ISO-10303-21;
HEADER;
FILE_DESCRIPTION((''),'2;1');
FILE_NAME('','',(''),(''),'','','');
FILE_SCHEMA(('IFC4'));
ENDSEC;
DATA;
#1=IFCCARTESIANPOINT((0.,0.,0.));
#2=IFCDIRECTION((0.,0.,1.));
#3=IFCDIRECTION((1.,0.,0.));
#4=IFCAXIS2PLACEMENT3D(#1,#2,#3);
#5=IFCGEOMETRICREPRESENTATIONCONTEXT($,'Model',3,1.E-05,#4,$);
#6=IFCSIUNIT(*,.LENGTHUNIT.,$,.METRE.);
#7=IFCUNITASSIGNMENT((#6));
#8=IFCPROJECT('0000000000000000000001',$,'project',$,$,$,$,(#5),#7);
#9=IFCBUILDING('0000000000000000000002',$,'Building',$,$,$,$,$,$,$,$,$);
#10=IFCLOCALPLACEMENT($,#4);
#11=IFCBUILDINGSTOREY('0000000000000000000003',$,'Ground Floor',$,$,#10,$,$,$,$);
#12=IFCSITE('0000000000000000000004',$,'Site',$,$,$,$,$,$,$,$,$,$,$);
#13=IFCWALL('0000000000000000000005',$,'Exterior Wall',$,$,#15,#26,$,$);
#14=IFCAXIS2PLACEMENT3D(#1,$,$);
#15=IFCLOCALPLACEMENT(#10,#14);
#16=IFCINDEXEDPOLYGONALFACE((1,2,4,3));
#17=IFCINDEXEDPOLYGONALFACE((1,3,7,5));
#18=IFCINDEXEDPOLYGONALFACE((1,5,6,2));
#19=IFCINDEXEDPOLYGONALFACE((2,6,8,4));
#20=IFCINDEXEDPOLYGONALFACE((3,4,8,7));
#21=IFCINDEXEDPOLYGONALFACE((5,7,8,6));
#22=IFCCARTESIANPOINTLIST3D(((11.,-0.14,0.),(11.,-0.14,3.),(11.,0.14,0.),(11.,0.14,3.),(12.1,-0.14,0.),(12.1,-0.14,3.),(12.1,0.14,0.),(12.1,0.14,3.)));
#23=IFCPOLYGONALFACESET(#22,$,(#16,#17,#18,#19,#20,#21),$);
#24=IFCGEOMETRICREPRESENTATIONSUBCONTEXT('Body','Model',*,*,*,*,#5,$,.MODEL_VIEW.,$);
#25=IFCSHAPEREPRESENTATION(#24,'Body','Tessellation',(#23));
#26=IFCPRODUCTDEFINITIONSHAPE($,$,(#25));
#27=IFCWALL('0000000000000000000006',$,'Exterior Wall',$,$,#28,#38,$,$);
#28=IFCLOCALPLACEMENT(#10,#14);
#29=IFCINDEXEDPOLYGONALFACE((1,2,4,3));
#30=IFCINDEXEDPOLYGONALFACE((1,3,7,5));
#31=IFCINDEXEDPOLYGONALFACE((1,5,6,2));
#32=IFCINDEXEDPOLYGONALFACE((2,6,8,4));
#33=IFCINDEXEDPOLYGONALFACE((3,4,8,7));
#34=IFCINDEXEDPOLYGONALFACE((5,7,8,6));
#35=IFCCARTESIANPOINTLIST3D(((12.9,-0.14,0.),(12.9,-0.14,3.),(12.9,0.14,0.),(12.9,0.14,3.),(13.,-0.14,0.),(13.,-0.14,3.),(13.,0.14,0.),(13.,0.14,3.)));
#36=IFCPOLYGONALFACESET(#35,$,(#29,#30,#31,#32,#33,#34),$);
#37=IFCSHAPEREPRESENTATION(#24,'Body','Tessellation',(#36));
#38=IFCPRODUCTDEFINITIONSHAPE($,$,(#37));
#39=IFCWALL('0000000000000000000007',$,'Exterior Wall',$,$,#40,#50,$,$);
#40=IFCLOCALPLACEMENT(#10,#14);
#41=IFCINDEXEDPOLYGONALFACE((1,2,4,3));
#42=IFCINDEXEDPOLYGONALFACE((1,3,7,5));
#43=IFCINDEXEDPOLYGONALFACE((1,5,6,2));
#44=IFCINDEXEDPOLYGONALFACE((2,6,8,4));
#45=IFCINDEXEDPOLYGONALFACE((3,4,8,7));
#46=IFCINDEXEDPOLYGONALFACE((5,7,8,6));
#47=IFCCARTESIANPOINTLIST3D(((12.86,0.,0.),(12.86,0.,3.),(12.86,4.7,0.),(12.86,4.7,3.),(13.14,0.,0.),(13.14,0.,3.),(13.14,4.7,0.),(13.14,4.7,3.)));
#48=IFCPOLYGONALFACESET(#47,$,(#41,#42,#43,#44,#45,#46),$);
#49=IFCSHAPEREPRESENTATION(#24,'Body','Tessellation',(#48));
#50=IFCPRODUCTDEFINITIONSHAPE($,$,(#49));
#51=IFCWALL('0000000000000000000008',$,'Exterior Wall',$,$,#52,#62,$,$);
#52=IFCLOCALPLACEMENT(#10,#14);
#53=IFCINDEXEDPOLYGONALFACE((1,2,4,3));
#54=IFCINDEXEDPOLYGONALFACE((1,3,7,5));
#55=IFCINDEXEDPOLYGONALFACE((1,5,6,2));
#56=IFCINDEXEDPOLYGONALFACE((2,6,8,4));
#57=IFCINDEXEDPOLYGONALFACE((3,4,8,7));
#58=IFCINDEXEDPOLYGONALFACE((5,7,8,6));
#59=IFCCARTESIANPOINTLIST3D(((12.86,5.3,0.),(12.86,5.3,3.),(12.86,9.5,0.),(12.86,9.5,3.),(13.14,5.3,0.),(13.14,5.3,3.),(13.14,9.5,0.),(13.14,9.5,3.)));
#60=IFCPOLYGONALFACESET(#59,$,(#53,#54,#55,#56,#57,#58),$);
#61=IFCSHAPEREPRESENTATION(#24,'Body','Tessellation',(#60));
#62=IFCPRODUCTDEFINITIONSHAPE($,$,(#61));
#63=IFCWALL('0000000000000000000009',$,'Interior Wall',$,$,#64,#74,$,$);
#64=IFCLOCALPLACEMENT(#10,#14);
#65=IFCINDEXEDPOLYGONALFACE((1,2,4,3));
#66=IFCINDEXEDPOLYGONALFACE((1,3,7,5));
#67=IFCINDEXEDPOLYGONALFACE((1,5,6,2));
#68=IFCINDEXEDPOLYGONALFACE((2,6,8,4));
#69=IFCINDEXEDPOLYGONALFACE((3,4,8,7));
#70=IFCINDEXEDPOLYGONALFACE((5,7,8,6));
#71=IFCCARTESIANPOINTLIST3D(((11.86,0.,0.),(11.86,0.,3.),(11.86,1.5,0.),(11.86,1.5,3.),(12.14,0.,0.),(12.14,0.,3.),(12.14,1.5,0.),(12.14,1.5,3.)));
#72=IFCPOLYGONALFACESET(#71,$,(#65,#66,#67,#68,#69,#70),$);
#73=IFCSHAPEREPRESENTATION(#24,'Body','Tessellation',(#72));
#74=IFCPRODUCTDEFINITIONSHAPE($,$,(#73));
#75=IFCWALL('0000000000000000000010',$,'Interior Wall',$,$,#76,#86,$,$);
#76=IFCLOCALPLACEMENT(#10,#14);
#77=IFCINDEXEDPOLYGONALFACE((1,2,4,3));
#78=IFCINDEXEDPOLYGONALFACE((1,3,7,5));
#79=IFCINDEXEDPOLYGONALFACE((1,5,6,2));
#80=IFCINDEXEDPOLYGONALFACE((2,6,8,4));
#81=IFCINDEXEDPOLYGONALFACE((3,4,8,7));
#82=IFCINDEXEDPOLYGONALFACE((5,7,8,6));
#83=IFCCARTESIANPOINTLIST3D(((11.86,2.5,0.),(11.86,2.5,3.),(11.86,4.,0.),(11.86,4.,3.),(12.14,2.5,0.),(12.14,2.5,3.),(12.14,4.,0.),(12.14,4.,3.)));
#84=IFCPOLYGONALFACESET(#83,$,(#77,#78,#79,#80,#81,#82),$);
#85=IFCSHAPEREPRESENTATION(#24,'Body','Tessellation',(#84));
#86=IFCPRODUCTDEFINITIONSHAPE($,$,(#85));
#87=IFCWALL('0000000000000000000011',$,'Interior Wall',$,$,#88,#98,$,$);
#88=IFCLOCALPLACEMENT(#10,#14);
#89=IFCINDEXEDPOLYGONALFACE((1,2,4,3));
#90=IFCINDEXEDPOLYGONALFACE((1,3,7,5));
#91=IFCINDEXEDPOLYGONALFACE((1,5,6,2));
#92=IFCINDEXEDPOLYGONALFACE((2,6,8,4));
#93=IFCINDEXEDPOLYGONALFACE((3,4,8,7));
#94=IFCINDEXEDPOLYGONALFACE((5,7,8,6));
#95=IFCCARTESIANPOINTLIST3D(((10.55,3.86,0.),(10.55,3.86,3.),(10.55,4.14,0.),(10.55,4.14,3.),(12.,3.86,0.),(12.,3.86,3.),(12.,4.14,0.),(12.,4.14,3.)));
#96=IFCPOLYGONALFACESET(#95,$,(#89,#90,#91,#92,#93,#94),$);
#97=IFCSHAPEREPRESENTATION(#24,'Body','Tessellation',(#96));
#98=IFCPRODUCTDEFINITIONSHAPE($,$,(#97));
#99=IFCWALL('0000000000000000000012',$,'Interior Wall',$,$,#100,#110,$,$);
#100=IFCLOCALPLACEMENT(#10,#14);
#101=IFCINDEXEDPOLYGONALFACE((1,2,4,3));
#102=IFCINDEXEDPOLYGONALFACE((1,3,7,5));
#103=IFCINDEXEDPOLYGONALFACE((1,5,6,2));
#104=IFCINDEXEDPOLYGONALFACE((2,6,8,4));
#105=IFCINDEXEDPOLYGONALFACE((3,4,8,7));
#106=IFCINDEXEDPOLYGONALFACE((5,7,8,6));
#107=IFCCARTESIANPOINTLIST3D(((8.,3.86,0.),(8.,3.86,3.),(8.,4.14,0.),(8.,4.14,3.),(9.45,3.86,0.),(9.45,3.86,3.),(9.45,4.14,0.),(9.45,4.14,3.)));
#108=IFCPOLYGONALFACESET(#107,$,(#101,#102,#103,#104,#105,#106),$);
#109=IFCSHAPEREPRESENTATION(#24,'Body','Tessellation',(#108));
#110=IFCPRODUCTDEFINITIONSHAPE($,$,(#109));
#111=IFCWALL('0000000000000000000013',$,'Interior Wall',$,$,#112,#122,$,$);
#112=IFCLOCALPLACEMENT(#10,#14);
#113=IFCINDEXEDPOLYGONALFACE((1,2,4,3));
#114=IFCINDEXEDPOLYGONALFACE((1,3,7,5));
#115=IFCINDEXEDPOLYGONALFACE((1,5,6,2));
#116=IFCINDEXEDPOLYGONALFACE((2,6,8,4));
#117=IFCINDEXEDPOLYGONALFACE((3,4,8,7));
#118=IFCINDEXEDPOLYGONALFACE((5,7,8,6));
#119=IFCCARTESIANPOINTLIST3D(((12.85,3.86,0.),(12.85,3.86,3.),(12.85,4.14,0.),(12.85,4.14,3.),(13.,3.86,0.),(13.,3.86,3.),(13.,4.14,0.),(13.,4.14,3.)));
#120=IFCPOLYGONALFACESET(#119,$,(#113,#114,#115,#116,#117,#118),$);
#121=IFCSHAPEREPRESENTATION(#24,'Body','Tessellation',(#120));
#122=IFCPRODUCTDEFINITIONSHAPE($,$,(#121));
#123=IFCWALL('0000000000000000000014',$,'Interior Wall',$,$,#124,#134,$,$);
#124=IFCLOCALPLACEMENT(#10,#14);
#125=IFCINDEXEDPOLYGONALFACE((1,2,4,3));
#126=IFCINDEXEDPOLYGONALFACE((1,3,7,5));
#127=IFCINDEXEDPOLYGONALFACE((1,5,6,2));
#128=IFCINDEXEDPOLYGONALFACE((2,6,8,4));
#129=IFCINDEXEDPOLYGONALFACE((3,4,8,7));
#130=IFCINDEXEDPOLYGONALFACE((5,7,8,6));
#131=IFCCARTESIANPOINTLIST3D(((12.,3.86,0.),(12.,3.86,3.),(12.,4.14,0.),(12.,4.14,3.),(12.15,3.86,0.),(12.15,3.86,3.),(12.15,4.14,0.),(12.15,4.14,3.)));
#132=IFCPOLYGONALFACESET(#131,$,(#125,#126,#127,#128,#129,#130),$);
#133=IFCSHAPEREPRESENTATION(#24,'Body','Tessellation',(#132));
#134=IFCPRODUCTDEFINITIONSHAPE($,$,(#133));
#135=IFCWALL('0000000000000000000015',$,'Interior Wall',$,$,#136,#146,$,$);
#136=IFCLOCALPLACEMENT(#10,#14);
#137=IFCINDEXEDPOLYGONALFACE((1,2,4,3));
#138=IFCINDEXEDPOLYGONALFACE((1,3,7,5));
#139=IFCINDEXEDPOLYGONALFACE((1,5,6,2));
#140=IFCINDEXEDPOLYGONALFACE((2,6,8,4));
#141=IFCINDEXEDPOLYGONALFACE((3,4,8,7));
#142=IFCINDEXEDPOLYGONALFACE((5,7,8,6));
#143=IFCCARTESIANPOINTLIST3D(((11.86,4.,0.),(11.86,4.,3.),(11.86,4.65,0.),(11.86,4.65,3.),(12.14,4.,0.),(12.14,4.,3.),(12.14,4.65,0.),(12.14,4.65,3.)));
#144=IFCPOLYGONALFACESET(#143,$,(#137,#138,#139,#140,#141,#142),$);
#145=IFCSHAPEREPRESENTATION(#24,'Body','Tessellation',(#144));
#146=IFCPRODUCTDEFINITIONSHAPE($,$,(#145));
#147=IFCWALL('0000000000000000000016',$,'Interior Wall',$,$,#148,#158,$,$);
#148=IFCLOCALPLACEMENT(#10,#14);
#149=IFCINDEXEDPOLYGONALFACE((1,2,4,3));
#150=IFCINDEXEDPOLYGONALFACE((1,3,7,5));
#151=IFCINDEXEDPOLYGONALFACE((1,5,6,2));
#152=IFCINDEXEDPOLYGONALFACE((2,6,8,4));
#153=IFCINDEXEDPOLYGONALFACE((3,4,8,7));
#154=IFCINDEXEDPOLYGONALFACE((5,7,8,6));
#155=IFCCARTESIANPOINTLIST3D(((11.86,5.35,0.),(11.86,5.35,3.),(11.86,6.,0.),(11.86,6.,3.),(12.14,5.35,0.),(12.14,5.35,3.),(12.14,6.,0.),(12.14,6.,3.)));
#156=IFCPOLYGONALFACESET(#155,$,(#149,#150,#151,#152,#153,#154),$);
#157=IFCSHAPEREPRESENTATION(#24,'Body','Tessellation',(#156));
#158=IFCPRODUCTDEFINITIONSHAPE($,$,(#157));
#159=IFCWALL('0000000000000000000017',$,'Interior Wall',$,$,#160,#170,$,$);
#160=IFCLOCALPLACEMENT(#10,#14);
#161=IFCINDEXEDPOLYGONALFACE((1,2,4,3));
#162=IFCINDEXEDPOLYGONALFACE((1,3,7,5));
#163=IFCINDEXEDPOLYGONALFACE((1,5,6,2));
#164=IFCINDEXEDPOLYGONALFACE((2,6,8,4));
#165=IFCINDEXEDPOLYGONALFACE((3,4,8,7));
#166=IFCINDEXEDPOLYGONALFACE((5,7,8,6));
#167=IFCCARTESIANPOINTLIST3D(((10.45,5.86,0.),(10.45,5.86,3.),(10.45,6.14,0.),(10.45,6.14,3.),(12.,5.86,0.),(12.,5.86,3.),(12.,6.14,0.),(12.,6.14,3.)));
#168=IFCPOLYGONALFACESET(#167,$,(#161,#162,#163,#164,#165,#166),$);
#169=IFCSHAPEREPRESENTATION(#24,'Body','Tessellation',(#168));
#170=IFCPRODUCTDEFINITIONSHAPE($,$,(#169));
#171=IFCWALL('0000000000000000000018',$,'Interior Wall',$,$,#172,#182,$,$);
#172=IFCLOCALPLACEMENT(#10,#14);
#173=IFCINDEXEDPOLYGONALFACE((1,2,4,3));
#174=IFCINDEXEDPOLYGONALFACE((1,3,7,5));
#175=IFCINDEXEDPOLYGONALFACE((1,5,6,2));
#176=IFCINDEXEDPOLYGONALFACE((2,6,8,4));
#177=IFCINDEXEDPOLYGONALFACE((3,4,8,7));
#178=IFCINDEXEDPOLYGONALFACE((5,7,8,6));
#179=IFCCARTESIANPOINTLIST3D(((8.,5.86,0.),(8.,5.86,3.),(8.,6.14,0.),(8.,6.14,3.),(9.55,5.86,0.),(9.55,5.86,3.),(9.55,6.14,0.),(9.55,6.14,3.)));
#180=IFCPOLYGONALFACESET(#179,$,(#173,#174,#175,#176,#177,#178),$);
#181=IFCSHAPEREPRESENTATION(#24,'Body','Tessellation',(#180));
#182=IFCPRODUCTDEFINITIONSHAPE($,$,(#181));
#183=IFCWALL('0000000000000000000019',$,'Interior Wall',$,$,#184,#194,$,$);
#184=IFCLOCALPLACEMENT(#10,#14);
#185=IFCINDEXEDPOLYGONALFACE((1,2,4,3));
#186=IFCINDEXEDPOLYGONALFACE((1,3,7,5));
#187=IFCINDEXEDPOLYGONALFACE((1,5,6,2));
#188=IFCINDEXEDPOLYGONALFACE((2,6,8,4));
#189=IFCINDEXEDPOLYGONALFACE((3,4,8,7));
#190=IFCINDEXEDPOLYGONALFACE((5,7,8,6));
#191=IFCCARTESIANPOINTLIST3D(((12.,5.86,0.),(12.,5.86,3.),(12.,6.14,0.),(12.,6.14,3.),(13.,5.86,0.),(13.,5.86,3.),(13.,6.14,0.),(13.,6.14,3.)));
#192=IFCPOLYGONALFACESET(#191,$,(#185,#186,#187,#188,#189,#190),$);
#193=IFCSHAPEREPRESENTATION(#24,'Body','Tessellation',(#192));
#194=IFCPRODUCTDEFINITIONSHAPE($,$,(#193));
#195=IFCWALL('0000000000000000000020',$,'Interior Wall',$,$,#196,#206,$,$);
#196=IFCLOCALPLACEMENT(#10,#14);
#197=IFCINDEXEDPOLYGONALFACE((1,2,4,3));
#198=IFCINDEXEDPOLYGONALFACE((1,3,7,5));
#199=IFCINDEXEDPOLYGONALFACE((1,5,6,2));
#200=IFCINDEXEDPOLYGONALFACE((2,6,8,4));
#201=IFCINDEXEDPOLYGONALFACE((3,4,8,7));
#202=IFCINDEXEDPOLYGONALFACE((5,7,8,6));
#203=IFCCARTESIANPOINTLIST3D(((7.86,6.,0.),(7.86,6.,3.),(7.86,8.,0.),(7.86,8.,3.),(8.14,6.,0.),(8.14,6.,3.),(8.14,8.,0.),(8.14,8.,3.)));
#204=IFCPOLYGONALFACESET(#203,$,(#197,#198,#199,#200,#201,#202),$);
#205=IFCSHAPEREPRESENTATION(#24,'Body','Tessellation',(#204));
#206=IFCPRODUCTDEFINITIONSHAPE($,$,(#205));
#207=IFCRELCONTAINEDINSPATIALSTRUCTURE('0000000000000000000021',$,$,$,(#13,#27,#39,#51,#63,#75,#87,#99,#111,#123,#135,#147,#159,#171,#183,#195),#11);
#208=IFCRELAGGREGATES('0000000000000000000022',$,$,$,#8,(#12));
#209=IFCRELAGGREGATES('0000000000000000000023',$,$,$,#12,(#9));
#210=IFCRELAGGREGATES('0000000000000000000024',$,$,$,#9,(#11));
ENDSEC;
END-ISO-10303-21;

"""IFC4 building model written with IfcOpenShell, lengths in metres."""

from ifc_helpers import new_model, si_unit, frame, origin_with_axes, place, context, subcontext, project, spatial, indexed_curve, outline, extrude, element, save


model = new_model("IFC4")

# Units and contexts
model_context = context("Model", 3, precision=1e-05, world=origin_with_axes())
body_context = subcontext(model_context, "Body", "Model", "MODEL_VIEW")
ifc_project = project(units=[si_unit("LENGTHUNIT", "METRE")], contexts=[model_context])

# Site, building, storey
site = spatial("IfcSite", under=ifc_project, Name="Site")
building = spatial("IfcBuilding", under=site, Name="Building")
storey_placement = place(None, origin_with_axes())
storey = spatial("IfcBuildingStorey", under=building, at=storey_placement, Name="Ground Floor")

# Walls
wall_1_placement = place(storey_placement, frame((11.0, 0.0, 0.0), z_axis=(0.0, 0.0, 1.0), x_axis=(1.0, 0.0, 0.0)))
element("IfcWall", 1, at=wall_1_placement, inside=storey, Name="Exterior Wall", context=body_context, shape_type="SweptSolid", body=[
    extrude(outline(indexed_curve([(0.0, 0.0), (0.0, 0.28), (1.1, 0.28), (1.1, 0.0), (0.0, 0.0)], self_intersect=False)), frame((0.0, -0.14, 0.0), z_axis=(0.0, 0.0, 1.0), x_axis=(1.0, 0.0, 0.0)), (0.0, 0.0, 1.0), 3.0),
])
wall_2_placement = place(storey_placement, frame((12.9, 0.0, 0.0), z_axis=(0.0, 0.0, 1.0), x_axis=(1.0, 0.0, 0.0)))
element("IfcWall", 2, at=wall_2_placement, inside=storey, Name="Exterior Wall", context=body_context, shape_type="SweptSolid", body=[
    extrude(outline(indexed_curve([(0.0, 0.0), (0.0, 0.28), (0.1, 0.28), (0.1, 0.0), (0.0, 0.0)], self_intersect=False)), frame((0.0, -0.14, 0.0), z_axis=(0.0, 0.0, 1.0), x_axis=(1.0, 0.0, 0.0)), (0.0, 0.0, 1.0), 3.0),
])
wall_3_placement = place(storey_placement, frame((13.0, 0.0, 0.0), z_axis=(0.0, 0.0, 1.0), x_axis=(0.0, 1.0, 0.0)))
element("IfcWall", 3, at=wall_3_placement, inside=storey, Name="Exterior Wall", context=body_context, shape_type="SweptSolid", body=[
    extrude(outline(indexed_curve([(0.0, 0.0), (0.0, 0.28), (4.7, 0.28), (4.7, 0.0), (0.0, 0.0)], self_intersect=False)), frame((0.0, -0.14, 0.0), z_axis=(0.0, 0.0, 1.0), x_axis=(1.0, 0.0, 0.0)), (0.0, 0.0, 1.0), 3.0),
])
wall_4_placement = place(storey_placement, frame((13.0, 5.3, 0.0), z_axis=(0.0, 0.0, 1.0), x_axis=(0.0, 1.0, 0.0)))
element("IfcWall", 4, at=wall_4_placement, inside=storey, Name="Exterior Wall", context=body_context, shape_type="SweptSolid", body=[
    extrude(outline(indexed_curve([(0.0, 0.0), (0.0, 0.28), (4.2, 0.28), (4.2, 0.0), (0.0, 0.0)], self_intersect=False)), frame((0.0, -0.14, 0.0), z_axis=(0.0, 0.0, 1.0), x_axis=(1.0, 0.0, 0.0)), (0.0, 0.0, 1.0), 3.0),
])
for number, where, z_axis, x_axis, name in (
    (5, (12.0, 0.0, 0.0), (0.0, 0.0, 1.0), (0.0, 1.0, 0.0), "Interior Wall"),
    (6, (12.0, 2.5, 0.0), (0.0, 0.0, 1.0), (0.0, 1.0, 0.0), "Interior Wall"),
):
    element("IfcWall", number, at=place(storey_placement, frame(where, z_axis=z_axis, x_axis=x_axis)), inside=storey, Name=name, context=body_context, shape_type="SweptSolid", body=[
        extrude(outline(indexed_curve([(0.0, 0.0), (0.0, 0.28), (1.5, 0.28), (1.5, 0.0), (0.0, 0.0)], self_intersect=False)), frame((0.0, -0.14, 0.0), z_axis=(0.0, 0.0, 1.0), x_axis=(1.0, 0.0, 0.0)), (0.0, 0.0, 1.0), 3.0),
    ])
for number, where, z_axis, x_axis, name in (
    (7, (12.0, 4.0, 0.0), (0.0, 0.0, 1.0), (-1.0, 0.0, 0.0), "Interior Wall"),
    (8, (9.45, 4.0, 0.0), (0.0, 0.0, 1.0), (-1.0, 0.0, 0.0), "Interior Wall"),
):
    element("IfcWall", number, at=place(storey_placement, frame(where, z_axis=z_axis, x_axis=x_axis)), inside=storey, Name=name, context=body_context, shape_type="SweptSolid", body=[
        extrude(outline(indexed_curve([(0.0, 0.0), (0.0, 0.28), (1.45, 0.28), (1.45, 0.0), (0.0, 0.0)], self_intersect=False)), frame((0.0, -0.14, 0.0), z_axis=(0.0, 0.0, 1.0), x_axis=(1.0, 0.0, 0.0)), (0.0, 0.0, 1.0), 3.0),
    ])
for number, where, z_axis, x_axis, name in (
    (9, (13.0, 4.0, 0.0), (0.0, 0.0, 1.0), (-1.0, 0.0, 0.0), "Interior Wall"),
    (10, (12.15, 4.0, 0.0), (0.0, 0.0, 1.0), (-1.0, 0.0, 0.0), "Interior Wall"),
):
    element("IfcWall", number, at=place(storey_placement, frame(where, z_axis=z_axis, x_axis=x_axis)), inside=storey, Name=name, context=body_context, shape_type="SweptSolid", body=[
        extrude(outline(indexed_curve([(0.0, 0.0), (0.0, 0.28), (0.15, 0.28), (0.15, 0.0), (0.0, 0.0)], self_intersect=False)), frame((0.0, -0.14, 0.0), z_axis=(0.0, 0.0, 1.0), x_axis=(1.0, 0.0, 0.0)), (0.0, 0.0, 1.0), 3.0),
    ])
for number, where, z_axis, x_axis, name in (
    (11, (12.0, 4.0, 0.0), (0.0, 0.0, 1.0), (0.0, 1.0, 0.0), "Interior Wall"),
    (12, (12.0, 5.35, 0.0), (0.0, 0.0, 1.0), (0.0, 1.0, 0.0), "Interior Wall"),
):
    element("IfcWall", number, at=place(storey_placement, frame(where, z_axis=z_axis, x_axis=x_axis)), inside=storey, Name=name, context=body_context, shape_type="SweptSolid", body=[
        extrude(outline(indexed_curve([(0.0, 0.0), (0.0, 0.28), (0.65, 0.28), (0.65, 0.0), (0.0, 0.0)], self_intersect=False)), frame((0.0, -0.14, 0.0), z_axis=(0.0, 0.0, 1.0), x_axis=(1.0, 0.0, 0.0)), (0.0, 0.0, 1.0), 3.0),
    ])
for number, where, z_axis, x_axis, name in (
    (13, (12.0, 6.0, 0.0), (0.0, 0.0, 1.0), (-1.0, 0.0, 0.0), "Interior Wall"),
    (14, (9.55, 6.0, 0.0), (0.0, 0.0, 1.0), (-1.0, 0.0, 0.0), "Interior Wall"),
):
    element("IfcWall", number, at=place(storey_placement, frame(where, z_axis=z_axis, x_axis=x_axis)), inside=storey, Name=name, context=body_context, shape_type="SweptSolid", body=[
        extrude(outline(indexed_curve([(0.0, 0.0), (0.0, 0.28), (1.55, 0.28), (1.55, 0.0), (0.0, 0.0)], self_intersect=False)), frame((0.0, -0.14, 0.0), z_axis=(0.0, 0.0, 1.0), x_axis=(1.0, 0.0, 0.0)), (0.0, 0.0, 1.0), 3.0),
    ])
wall_5_placement = place(storey_placement, frame((13.0, 6.0, 0.0), z_axis=(0.0, 0.0, 1.0), x_axis=(-1.0, 0.0, 0.0)))
element("IfcWall", 15, at=wall_5_placement, inside=storey, Name="Interior Wall", context=body_context, shape_type="SweptSolid", body=[
    extrude(outline(indexed_curve([(0.0, 0.0), (0.0, 0.28), (1.0, 0.28), (1.0, 0.0), (0.0, 0.0)], self_intersect=False)), frame((0.0, -0.14, 0.0), z_axis=(0.0, 0.0, 1.0), x_axis=(1.0, 0.0, 0.0)), (0.0, 0.0, 1.0), 3.0),
])
wall_6_placement = place(storey_placement, frame((8.0, 6.0, 0.0), z_axis=(0.0, 0.0, 1.0), x_axis=(0.0, 1.0, 0.0)))
element("IfcWall", 16, at=wall_6_placement, inside=storey, Name="Interior Wall", context=body_context, shape_type="SweptSolid", body=[
    extrude(outline(indexed_curve([(0.0, 0.0), (0.0, 0.28), (2.0, 0.28), (2.0, 0.0), (0.0, 0.0)], self_intersect=False)), frame((0.0, -0.14, 0.0), z_axis=(0.0, 0.0, 1.0), x_axis=(1.0, 0.0, 0.0)), (0.0, 0.0, 1.0), 3.0),
])

save(model, "model.ifc")
